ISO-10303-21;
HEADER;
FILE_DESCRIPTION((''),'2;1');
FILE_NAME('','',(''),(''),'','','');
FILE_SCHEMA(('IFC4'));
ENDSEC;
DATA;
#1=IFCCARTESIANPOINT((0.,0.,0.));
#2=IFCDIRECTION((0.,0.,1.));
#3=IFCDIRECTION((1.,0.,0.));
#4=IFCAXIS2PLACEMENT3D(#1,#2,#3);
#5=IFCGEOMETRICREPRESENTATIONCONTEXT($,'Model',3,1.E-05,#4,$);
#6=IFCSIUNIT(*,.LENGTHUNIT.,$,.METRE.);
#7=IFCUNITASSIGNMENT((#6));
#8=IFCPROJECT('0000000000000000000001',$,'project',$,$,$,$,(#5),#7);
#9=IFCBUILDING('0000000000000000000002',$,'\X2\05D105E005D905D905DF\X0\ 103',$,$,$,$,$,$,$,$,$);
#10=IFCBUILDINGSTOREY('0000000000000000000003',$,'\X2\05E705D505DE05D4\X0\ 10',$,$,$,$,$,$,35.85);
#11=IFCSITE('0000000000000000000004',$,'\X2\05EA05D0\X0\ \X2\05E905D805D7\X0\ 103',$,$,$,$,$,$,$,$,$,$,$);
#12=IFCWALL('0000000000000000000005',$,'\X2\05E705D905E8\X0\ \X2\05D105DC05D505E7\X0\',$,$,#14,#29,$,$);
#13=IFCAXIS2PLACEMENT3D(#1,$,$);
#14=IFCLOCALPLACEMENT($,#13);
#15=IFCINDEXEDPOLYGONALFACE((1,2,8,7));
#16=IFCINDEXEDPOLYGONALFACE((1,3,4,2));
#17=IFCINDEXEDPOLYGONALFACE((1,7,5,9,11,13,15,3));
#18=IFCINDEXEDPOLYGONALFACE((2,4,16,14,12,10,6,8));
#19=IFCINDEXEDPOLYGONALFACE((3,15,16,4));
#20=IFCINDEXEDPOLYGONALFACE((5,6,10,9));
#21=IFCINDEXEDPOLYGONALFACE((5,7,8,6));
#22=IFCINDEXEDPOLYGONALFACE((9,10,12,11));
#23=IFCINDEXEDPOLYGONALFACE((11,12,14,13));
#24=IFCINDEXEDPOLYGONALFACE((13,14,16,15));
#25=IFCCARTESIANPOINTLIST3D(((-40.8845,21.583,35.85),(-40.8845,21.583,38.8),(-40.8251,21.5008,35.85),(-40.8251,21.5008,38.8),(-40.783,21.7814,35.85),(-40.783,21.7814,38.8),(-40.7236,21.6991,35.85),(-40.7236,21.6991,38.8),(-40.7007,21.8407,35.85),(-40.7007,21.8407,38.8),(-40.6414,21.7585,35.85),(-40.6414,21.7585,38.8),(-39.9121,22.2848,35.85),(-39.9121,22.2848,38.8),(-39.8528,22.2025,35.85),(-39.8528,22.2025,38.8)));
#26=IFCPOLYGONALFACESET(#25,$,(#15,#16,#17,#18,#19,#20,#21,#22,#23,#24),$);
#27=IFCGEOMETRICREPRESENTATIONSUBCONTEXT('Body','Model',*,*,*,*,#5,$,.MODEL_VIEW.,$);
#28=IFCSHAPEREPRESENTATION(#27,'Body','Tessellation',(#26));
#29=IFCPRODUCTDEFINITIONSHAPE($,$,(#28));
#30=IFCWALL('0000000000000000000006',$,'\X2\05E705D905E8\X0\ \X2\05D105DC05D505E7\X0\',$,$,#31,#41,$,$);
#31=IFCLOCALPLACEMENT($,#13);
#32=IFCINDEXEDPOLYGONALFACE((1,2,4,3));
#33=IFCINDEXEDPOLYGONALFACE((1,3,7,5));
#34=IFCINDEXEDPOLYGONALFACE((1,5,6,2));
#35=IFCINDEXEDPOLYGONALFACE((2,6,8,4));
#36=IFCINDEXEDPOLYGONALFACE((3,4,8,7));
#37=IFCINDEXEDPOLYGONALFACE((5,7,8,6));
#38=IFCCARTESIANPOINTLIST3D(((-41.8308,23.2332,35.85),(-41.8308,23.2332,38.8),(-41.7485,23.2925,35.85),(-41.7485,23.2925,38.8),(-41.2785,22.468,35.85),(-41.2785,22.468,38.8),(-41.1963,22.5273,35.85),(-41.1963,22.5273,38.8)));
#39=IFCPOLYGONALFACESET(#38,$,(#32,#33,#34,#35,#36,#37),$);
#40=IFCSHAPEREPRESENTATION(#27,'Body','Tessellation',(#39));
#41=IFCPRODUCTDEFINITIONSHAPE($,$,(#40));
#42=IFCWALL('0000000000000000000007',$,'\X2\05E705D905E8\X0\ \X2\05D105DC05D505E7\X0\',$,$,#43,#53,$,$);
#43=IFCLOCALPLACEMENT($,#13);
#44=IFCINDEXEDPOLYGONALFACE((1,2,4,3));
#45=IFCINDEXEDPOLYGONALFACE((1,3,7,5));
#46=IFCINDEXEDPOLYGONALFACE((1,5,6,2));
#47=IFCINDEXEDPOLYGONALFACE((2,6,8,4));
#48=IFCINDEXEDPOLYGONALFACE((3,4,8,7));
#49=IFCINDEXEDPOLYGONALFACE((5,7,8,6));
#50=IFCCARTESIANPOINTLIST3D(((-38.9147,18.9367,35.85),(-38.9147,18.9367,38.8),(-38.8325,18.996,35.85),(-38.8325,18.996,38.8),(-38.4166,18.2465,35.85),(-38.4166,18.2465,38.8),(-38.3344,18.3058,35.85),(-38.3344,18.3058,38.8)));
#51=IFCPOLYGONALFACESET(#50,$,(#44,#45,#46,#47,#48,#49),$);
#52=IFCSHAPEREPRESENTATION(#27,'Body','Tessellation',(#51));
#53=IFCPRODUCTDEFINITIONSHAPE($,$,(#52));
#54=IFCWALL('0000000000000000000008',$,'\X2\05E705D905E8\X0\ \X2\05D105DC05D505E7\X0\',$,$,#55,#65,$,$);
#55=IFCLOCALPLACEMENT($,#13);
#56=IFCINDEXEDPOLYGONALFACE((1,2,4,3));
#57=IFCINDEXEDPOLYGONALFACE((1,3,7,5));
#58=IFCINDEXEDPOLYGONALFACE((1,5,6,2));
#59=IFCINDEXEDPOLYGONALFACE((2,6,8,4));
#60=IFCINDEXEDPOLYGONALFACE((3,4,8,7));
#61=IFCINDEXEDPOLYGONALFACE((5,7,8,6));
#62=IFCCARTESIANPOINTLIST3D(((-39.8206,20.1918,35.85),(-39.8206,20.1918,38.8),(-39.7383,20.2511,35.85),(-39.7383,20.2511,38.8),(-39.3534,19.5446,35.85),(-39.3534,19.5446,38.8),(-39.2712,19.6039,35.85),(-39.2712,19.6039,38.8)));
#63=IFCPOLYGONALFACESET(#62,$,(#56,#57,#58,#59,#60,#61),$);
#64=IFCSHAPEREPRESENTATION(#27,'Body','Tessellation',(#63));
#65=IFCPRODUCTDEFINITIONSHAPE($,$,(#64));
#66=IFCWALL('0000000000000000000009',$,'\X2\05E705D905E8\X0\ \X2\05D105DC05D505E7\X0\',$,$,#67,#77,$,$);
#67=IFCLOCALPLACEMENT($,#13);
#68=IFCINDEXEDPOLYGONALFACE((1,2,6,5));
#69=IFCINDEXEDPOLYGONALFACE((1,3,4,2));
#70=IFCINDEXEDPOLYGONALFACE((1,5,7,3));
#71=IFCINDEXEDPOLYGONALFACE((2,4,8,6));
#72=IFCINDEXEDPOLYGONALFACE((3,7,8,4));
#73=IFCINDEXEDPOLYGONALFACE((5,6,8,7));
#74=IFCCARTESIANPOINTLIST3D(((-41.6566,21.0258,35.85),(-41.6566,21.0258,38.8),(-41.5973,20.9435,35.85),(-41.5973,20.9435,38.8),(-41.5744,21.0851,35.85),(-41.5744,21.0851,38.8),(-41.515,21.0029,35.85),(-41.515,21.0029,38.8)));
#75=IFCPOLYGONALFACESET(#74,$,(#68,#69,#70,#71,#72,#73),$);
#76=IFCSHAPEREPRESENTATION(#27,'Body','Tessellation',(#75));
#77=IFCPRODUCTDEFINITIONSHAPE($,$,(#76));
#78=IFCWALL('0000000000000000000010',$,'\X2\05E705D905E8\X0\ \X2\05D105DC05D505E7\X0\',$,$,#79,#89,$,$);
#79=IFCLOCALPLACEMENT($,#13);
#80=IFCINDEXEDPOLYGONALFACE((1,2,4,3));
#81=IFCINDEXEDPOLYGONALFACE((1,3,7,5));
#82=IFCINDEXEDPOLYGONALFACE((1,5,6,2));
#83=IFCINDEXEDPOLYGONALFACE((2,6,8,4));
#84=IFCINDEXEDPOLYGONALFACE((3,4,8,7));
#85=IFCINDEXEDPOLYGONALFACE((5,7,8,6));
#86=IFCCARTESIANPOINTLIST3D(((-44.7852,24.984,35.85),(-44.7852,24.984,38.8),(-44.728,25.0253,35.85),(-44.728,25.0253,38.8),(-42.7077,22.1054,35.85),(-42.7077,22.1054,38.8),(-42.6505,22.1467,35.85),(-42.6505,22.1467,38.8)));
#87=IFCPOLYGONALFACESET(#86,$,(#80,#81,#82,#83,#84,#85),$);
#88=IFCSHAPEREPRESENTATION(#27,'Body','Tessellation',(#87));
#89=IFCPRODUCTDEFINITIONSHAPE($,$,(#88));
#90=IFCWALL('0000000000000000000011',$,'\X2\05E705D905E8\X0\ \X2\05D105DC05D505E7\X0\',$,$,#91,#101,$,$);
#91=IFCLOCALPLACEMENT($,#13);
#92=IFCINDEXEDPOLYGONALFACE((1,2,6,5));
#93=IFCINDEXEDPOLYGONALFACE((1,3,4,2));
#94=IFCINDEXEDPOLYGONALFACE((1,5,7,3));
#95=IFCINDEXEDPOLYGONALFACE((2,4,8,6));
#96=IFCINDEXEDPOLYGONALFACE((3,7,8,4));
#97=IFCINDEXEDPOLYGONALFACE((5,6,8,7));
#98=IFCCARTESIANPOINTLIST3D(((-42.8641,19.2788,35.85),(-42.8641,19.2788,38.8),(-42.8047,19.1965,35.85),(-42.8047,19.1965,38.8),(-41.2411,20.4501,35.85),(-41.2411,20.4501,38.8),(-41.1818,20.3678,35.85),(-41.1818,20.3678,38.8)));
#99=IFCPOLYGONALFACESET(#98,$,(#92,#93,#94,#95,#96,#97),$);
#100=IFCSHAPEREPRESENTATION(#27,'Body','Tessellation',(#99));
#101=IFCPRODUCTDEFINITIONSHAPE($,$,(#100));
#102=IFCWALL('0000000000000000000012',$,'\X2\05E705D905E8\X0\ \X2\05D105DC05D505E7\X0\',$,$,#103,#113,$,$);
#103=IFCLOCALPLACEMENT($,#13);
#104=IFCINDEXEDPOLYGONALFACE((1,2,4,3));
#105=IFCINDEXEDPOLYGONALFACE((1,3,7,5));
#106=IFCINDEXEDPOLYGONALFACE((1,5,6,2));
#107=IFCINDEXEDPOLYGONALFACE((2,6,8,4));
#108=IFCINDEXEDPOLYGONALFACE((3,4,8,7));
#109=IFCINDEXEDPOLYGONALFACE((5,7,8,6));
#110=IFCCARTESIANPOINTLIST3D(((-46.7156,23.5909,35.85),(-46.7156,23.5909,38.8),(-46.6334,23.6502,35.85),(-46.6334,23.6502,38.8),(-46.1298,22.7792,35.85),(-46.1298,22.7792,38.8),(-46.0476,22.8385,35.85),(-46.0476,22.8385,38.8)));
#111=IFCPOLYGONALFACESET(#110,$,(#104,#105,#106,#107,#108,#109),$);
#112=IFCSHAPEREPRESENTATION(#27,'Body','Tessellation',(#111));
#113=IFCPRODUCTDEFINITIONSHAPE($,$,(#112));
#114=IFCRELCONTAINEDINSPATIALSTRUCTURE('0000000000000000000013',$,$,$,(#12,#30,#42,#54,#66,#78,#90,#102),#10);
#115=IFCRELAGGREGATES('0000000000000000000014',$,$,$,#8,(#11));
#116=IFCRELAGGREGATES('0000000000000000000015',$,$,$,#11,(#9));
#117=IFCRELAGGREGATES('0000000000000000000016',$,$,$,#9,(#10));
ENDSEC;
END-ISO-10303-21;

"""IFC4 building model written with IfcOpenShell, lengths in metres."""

from ifc_helpers import new_model, si_unit, frame, origin_with_axes, context, subcontext, project, spatial, polyline, outline, extrude, element, save


model = new_model("IFC4")

# Units and contexts
model_context = context("Model", 3, precision=1e-05, world=origin_with_axes())
body_context = subcontext(model_context, "Body", "Model", "MODEL_VIEW")
ifc_project = project(units=[si_unit("LENGTHUNIT", "METRE")], contexts=[model_context])

# Site, building, storey
site = spatial("IfcSite", under=ifc_project, Name="תא שטח 103")
building = spatial("IfcBuilding", under=site, Name="בניין 103")
storey = spatial("IfcBuildingStorey", under=building, Name="קומה 10", Elevation=35.85)

# Walls
element("IfcWall", 1, inside=storey, Name="קיר בלוק", context=body_context, shape_type="SweptSolid", body=[
    extrude(outline(polyline([(-40.783, 21.7814), (-40.7007, 21.8407), (-40.6414, 21.7585), (-39.9121, 22.2848), (-39.8528, 22.2025), (-40.8251, 21.5008), (-40.8845, 21.583), (-40.7236, 21.6991), (-40.783, 21.7814)])), frame((0.0, 0.0, 35.85)), (0.0, 0.0, 1.0), 2.95),
])
element("IfcWall", 2, inside=storey, Name="קיר בלוק", context=body_context, shape_type="SweptSolid", body=[
    extrude(outline(polyline([(-41.1963, 22.5273), (-41.2785, 22.468), (-41.8308, 23.2332), (-41.7485, 23.2925), (-41.1963, 22.5273)])), frame((0.0, 0.0, 35.85)), (0.0, 0.0, 1.0), 2.95),
])
element("IfcWall", 3, inside=storey, Name="קיר בלוק", context=body_context, shape_type="SweptSolid", body=[
    extrude(outline(polyline([(-38.4166, 18.2465), (-38.9147, 18.9367), (-38.8325, 18.996), (-38.3344, 18.3058), (-38.4166, 18.2465)])), frame((0.0, 0.0, 35.85)), (0.0, 0.0, 1.0), 2.95),
])
element("IfcWall", 4, inside=storey, Name="קיר בלוק", context=body_context, shape_type="SweptSolid", body=[
    extrude(outline(polyline([(-39.2712, 19.6039), (-39.3534, 19.5446), (-39.8206, 20.1918), (-39.7383, 20.2511), (-39.2712, 19.6039)])), frame((0.0, 0.0, 35.85)), (0.0, 0.0, 1.0), 2.95),
])
element("IfcWall", 5, inside=storey, Name="קיר בלוק", context=body_context, shape_type="SweptSolid", body=[
    extrude(outline(polyline([(-41.5744, 21.0851), (-41.515, 21.0029), (-41.5973, 20.9435), (-41.6566, 21.0258), (-41.5744, 21.0851)])), frame((0.0, 0.0, 35.85)), (0.0, 0.0, 1.0), 2.95),
])
element("IfcWall", 6, inside=storey, Name="קיר בלוק", context=body_context, shape_type="SweptSolid", body=[
    extrude(outline(polyline([(-42.6505, 22.1467), (-42.7077, 22.1054), (-44.7852, 24.984), (-44.728, 25.0253), (-42.6505, 22.1467)])), frame((0.0, 0.0, 35.85)), (0.0, 0.0, 1.0), 2.95),
])
element("IfcWall", 7, inside=storey, Name="קיר בלוק", context=body_context, shape_type="SweptSolid", body=[
    extrude(outline(polyline([(-42.8047, 19.1965), (-42.8641, 19.2788), (-41.2411, 20.4501), (-41.1818, 20.3678), (-42.8047, 19.1965)])), frame((0.0, 0.0, 35.85)), (0.0, 0.0, 1.0), 2.95),
])
element("IfcWall", 8, inside=storey, Name="קיר בלוק", context=body_context, shape_type="SweptSolid", body=[
    extrude(outline(polyline([(-46.6334, 23.6502), (-46.0476, 22.8385), (-46.1298, 22.7792), (-46.7156, 23.5909), (-46.6334, 23.6502)])), frame((0.0, 0.0, 35.85)), (0.0, 0.0, 1.0), 2.95),
])

save(model, "model.ifc")
